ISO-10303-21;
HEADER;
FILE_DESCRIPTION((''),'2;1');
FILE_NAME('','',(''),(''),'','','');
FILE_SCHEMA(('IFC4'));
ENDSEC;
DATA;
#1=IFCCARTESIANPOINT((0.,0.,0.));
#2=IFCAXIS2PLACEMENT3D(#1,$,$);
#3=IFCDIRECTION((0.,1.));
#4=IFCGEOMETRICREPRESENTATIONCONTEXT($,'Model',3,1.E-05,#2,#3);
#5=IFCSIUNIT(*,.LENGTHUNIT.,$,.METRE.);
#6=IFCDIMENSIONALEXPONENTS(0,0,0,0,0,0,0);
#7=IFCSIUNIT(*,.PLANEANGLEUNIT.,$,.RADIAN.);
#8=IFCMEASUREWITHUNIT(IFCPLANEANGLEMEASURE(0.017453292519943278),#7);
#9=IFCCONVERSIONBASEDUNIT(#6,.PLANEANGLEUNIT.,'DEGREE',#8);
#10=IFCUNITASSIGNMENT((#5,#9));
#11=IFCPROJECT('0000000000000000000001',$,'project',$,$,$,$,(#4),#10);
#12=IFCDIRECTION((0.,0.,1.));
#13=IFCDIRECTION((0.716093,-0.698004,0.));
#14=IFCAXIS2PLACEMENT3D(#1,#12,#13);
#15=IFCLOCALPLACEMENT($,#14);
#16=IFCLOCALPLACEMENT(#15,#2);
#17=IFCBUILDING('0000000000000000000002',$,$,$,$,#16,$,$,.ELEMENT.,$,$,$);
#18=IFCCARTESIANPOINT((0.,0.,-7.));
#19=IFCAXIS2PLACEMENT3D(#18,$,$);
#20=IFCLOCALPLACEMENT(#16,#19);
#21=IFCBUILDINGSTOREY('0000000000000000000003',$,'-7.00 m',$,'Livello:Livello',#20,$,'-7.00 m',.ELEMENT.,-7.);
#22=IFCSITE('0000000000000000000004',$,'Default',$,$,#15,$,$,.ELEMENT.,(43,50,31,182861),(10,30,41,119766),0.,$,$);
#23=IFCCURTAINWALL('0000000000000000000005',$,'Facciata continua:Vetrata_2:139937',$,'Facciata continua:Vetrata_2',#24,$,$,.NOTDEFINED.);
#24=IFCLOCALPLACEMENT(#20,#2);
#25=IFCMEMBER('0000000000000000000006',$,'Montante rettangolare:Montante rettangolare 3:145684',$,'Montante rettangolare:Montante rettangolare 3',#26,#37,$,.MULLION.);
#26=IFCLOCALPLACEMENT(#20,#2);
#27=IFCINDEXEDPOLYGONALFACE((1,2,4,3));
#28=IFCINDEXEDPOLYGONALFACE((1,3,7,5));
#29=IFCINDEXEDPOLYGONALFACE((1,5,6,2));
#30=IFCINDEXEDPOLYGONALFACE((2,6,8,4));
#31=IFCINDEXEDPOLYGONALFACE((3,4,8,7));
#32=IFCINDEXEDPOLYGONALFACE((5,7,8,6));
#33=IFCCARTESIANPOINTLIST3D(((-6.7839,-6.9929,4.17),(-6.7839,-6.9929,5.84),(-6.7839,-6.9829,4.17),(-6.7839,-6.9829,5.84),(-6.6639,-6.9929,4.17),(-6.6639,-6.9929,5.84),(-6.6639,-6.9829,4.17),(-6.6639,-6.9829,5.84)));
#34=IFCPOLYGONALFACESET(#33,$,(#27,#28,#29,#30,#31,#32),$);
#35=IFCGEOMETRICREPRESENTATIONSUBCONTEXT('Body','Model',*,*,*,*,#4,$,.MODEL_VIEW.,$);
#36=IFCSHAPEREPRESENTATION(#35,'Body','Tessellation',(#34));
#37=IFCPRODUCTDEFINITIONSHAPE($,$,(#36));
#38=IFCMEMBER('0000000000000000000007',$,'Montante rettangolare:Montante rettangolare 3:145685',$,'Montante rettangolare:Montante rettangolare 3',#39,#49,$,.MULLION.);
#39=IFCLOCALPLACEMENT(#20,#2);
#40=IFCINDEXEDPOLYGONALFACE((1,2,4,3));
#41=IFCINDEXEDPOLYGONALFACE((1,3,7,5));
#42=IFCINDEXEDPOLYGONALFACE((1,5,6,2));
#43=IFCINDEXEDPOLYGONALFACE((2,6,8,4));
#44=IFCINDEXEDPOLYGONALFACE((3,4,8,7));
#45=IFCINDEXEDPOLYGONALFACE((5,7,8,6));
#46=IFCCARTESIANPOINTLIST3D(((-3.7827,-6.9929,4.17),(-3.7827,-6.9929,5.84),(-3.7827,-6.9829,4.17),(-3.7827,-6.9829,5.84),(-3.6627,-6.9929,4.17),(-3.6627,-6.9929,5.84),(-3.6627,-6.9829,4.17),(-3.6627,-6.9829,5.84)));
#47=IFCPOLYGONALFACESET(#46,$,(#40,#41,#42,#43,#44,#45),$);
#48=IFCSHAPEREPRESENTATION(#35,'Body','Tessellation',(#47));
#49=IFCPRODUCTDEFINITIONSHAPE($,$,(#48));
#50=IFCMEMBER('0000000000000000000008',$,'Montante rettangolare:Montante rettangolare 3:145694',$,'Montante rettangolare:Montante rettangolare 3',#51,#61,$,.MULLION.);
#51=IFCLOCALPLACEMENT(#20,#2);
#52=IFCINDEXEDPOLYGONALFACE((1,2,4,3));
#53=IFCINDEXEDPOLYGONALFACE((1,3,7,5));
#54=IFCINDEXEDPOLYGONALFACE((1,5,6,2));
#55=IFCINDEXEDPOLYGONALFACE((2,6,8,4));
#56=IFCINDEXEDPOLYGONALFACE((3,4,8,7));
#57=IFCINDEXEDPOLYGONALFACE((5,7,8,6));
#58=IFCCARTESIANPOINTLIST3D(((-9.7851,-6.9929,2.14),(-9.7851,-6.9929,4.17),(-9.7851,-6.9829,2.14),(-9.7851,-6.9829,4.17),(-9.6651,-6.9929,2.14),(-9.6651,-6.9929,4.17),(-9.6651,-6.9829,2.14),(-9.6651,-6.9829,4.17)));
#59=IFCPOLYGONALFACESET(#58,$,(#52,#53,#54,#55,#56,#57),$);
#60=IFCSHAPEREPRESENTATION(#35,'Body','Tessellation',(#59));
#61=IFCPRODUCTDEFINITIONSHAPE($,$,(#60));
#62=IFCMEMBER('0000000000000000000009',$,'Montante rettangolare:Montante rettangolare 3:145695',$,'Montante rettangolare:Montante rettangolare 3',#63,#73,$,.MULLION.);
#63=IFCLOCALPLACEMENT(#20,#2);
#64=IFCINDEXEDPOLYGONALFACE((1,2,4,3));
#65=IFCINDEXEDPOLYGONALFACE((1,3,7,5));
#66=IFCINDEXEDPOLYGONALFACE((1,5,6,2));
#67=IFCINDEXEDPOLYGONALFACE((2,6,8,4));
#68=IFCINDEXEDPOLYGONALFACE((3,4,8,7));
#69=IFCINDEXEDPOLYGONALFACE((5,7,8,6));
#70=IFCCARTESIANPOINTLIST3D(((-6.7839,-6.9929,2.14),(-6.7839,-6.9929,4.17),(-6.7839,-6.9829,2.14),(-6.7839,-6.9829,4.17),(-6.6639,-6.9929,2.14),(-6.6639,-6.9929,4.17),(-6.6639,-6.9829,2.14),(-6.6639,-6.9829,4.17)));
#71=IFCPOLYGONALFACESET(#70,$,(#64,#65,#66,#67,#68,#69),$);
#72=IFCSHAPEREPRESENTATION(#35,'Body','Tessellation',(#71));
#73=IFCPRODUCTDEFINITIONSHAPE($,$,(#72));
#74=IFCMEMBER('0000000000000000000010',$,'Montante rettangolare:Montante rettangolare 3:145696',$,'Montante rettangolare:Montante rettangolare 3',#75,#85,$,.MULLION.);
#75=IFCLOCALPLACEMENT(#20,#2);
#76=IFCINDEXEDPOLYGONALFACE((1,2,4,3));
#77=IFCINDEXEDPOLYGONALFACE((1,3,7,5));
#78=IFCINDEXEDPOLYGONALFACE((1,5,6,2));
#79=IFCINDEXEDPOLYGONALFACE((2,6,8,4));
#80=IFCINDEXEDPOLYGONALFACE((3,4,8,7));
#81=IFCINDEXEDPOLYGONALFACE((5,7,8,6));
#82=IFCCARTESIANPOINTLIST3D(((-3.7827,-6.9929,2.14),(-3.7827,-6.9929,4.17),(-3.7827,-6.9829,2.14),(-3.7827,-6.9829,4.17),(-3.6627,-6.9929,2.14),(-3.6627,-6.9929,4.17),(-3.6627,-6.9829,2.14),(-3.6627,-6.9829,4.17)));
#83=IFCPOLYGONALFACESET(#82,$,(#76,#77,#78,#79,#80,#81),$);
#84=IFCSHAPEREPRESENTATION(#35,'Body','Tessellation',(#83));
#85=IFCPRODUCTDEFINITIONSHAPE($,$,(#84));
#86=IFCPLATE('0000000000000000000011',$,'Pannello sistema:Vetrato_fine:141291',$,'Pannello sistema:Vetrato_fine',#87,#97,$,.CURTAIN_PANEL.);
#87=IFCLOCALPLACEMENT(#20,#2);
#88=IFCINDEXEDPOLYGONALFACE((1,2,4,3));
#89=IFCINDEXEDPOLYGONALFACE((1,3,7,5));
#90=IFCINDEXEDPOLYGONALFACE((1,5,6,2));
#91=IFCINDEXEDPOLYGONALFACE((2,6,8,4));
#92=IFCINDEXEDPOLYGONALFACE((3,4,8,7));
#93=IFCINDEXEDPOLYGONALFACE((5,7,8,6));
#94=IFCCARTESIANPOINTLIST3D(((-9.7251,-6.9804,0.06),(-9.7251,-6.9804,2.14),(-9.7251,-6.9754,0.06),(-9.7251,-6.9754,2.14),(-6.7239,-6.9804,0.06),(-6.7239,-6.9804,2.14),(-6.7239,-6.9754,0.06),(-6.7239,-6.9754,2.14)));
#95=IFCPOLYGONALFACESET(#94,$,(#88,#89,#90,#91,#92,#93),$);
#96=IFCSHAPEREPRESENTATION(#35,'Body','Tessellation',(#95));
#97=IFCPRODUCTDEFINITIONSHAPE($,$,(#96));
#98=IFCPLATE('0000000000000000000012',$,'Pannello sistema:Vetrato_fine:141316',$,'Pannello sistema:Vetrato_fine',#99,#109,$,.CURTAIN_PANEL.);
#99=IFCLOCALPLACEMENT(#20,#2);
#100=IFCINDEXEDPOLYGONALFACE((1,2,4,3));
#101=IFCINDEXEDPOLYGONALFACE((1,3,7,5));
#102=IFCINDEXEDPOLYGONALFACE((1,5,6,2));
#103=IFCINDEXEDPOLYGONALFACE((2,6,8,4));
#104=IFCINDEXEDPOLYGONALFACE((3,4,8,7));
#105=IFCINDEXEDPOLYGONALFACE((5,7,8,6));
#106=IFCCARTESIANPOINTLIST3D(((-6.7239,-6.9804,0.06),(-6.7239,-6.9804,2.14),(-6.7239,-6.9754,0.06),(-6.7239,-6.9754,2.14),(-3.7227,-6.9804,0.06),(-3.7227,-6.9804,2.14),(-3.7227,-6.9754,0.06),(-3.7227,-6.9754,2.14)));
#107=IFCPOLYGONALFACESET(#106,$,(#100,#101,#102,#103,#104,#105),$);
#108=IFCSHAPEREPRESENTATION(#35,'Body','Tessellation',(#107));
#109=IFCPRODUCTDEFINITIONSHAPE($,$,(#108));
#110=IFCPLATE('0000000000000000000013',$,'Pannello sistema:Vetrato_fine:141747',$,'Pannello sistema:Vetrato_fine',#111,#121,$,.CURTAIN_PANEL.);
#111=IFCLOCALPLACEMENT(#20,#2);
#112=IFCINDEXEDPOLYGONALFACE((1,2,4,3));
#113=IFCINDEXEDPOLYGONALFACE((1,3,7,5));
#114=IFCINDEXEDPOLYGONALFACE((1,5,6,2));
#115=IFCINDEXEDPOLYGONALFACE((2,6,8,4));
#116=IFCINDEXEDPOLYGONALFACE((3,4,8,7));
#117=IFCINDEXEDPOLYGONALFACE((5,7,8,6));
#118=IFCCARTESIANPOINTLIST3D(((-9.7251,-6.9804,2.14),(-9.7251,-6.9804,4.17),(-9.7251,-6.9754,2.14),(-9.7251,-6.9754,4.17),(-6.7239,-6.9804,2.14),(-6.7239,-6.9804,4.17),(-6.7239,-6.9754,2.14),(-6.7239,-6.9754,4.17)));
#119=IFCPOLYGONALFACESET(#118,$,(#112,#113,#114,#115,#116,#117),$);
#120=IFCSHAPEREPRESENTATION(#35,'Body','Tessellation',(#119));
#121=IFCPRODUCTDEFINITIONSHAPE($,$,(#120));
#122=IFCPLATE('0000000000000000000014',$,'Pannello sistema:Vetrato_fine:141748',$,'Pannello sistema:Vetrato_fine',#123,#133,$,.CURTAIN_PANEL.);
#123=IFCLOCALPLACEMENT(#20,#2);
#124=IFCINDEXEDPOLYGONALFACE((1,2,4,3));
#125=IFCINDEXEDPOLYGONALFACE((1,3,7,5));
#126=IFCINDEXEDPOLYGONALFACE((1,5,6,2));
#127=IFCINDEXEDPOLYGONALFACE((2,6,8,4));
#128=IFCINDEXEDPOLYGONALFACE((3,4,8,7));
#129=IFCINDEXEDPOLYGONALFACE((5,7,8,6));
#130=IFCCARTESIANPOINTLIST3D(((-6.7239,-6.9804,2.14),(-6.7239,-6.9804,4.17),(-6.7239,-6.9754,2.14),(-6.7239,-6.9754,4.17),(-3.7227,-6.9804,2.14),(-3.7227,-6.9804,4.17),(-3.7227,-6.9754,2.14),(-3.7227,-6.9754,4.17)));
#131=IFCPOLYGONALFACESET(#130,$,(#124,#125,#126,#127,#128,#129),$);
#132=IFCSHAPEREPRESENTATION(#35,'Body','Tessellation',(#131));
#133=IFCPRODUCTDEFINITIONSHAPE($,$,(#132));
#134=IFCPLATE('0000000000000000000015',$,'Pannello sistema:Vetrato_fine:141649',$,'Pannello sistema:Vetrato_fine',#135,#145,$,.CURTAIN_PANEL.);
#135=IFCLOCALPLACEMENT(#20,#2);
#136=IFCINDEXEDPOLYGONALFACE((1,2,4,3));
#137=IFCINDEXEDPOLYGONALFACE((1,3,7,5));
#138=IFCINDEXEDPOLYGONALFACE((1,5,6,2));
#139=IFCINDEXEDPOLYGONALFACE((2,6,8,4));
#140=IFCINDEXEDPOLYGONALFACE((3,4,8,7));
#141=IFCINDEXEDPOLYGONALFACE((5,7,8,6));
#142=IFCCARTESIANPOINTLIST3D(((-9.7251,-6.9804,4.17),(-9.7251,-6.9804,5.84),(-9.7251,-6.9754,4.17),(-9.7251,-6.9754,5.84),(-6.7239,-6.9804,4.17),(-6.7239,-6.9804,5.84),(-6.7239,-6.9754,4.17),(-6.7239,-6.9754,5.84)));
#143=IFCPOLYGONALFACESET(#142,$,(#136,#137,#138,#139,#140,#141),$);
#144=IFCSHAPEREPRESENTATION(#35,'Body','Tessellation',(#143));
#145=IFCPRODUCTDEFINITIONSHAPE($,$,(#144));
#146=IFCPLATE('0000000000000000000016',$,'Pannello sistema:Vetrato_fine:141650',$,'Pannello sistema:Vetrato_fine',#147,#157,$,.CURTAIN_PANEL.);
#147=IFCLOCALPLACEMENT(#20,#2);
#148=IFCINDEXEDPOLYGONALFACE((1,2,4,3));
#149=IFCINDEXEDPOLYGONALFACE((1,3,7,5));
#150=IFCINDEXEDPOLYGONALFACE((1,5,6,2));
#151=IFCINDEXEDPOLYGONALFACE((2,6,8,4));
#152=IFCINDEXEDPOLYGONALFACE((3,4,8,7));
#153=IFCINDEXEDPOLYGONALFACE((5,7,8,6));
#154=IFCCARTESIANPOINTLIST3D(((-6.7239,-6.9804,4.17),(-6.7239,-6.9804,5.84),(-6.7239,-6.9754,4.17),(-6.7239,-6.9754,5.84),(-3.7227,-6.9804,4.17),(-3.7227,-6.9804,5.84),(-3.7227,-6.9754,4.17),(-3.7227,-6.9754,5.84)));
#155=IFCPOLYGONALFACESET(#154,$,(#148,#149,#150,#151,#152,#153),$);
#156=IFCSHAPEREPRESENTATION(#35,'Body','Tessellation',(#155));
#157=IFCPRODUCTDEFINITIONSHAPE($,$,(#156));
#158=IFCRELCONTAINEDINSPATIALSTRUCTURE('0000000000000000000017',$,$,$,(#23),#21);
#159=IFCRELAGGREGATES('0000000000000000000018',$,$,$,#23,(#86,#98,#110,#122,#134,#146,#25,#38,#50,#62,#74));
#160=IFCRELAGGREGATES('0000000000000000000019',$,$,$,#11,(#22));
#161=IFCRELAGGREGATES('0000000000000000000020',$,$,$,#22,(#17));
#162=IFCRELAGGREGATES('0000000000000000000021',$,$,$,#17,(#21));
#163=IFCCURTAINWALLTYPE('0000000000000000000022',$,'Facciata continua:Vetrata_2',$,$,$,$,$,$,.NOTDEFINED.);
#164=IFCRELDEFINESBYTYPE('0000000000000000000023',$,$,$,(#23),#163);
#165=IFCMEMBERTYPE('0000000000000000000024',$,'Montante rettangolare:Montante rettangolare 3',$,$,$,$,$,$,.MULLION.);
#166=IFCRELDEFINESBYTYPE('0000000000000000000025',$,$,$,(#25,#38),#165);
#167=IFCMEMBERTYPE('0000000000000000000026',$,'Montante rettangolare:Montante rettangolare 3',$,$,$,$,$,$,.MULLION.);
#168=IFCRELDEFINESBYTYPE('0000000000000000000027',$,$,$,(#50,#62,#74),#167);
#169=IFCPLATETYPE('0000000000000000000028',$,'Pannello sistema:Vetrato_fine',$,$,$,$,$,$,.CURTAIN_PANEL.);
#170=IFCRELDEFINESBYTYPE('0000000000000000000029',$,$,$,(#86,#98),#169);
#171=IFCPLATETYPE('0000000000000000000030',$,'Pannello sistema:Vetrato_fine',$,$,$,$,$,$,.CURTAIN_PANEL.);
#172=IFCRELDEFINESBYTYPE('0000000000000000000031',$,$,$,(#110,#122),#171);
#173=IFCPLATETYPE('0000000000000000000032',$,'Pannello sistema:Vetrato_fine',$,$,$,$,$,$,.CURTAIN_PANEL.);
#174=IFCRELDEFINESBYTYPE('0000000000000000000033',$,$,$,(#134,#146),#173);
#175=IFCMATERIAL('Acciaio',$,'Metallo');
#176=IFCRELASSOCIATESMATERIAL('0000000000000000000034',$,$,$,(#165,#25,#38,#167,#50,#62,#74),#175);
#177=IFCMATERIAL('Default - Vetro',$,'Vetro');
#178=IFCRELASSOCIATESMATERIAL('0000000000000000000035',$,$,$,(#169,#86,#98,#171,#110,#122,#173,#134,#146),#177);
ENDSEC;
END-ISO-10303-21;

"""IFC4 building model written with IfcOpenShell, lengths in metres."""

from ifc_helpers import new_model, entity, si_unit, converted_unit, direction, frame, origin, place, context, subcontext, project, spatial, indexed_curve, outline, extrude, source, transform, mapped, material, type_object, type_shapes, element, aggregate, save


model = new_model("IFC4")

# Units and contexts
model_context = context("Model", 3, precision=1e-05, world=origin(), true_north=direction((0.0, 1.0)))
body_context = subcontext(model_context, "Body", "Model", "MODEL_VIEW")
ifc_project = project(units=[si_unit("LENGTHUNIT", "METRE"), converted_unit("PLANEANGLEUNIT", "DEGREE", entity("IfcPlaneAngleMeasure", 0.017453292519943278), si_unit("PLANEANGLEUNIT", "RADIAN"), dimensions=[0, 0, 0, 0, 0, 0, 0])], contexts=[model_context])

# Site, building, storey
site_placement = place(None, frame((0.0, 0.0, 0.0), z_axis=(0.0, 0.0, 1.0), x_axis=(0.716093, -0.698004, 0.0)))
site = spatial("IfcSite", under=ifc_project, at=site_placement, Name="Default", CompositionType="ELEMENT", RefLatitude=(43, 50, 31, 182861), RefLongitude=(10, 30, 41, 119766), RefElevation=0.0)
building_placement = place(site_placement, origin())
building = spatial("IfcBuilding", under=site, at=building_placement, CompositionType="ELEMENT")
storey_placement = place(building_placement, frame((0.0, 0.0, -7.0)))
storey = spatial("IfcBuildingStorey", under=building, at=storey_placement, Name="-7.00 m", ObjectType="Livello:Livello", LongName="-7.00 m", CompositionType="ELEMENT", Elevation=-7.0)

# Curtain wall, members, plates
curtain_wall_type = type_object("IfcCurtainWallType", Name="Facciata continua:Vetrata_2", PredefinedType="NOTDEFINED")
curtain_wall_placement = place(storey_placement, frame((0.0, 0.0, 7.0)))
curtain_wall = element("IfcCurtainWall", 1, at=curtain_wall_placement, inside=storey, type_object=curtain_wall_type, Name="Facciata continua:Vetrata_2:139937", ObjectType="Facciata continua:Vetrata_2", PredefinedType="NOTDEFINED")
ifc_material_1 = material(Name="Acciaio", Category="Metallo")
member_type_1 = type_object("IfcMemberType", Name="Montante rettangolare:Montante rettangolare 3", PredefinedType="MULLION", material=ifc_material_1)
shared_shape_1 = source(origin(), body_context, "Body", "SweptSolid", [
    extrude(outline(indexed_curve([(-0.06, -0.005), (0.06, -0.005), (0.06, 0.005), (-0.06, 0.005), (-0.06, -0.005)], self_intersect=False)), frame((0.0, 0.01, -1.67), z_axis=(0.0, 0.0, 1.0), x_axis=(-1.0, 0.0, 0.0)), (0.0, 0.0, 1.0), 1.67),
])
type_shapes(member_type_1, [shared_shape_1])
member_1_placement = place(curtain_wall_placement, frame((-6.7239, -6.9779, -2.83), z_axis=(0.0, 0.0, -1.0), x_axis=(1.0, 0.0, 0.0)))
member_1 = element("IfcMember", 2, at=member_1_placement, type_object=member_type_1, material=ifc_material_1, Name="Montante rettangolare:Montante rettangolare 3:145684", ObjectType="Montante rettangolare:Montante rettangolare 3", PredefinedType="MULLION", context=body_context, shape_type="MappedRepresentation", body=[
    mapped(shared_shape_1, transform((0.0, 0.0, 0.0), scale=1.0)),
])
member_2_placement = place(curtain_wall_placement, frame((-3.7227, -6.9779, -2.83), z_axis=(0.0, 0.0, -1.0), x_axis=(1.0, 0.0, 0.0)))
member_2 = element("IfcMember", 3, at=member_2_placement, type_object=member_type_1, material=ifc_material_1, Name="Montante rettangolare:Montante rettangolare 3:145685", ObjectType="Montante rettangolare:Montante rettangolare 3", PredefinedType="MULLION", context=body_context, shape_type="MappedRepresentation", body=[
    mapped(shared_shape_1, transform((0.0, 0.0, 0.0), scale=1.0)),
])
member_type_2 = type_object("IfcMemberType", Name="Montante rettangolare:Montante rettangolare 3", PredefinedType="MULLION", material=ifc_material_1)
shared_shape_2 = source(origin(), body_context, "Body", "SweptSolid", [
    extrude(outline(indexed_curve([(-0.06, -0.005), (0.06, -0.005), (0.06, 0.005), (-0.06, 0.005), (-0.06, -0.005)], self_intersect=False)), frame((0.0, 0.01, -2.03), z_axis=(0.0, 0.0, 1.0), x_axis=(-1.0, 0.0, 0.0)), (0.0, 0.0, 1.0), 2.03),
])
type_shapes(member_type_2, [shared_shape_2])
member_3_placement = place(curtain_wall_placement, frame((-9.7251, -6.9779, -4.86), z_axis=(0.0, 0.0, -1.0), x_axis=(1.0, 0.0, 0.0)))
member_3 = element("IfcMember", 4, at=member_3_placement, type_object=member_type_2, material=ifc_material_1, Name="Montante rettangolare:Montante rettangolare 3:145694", ObjectType="Montante rettangolare:Montante rettangolare 3", PredefinedType="MULLION", context=body_context, shape_type="MappedRepresentation", body=[
    mapped(shared_shape_2, transform((0.0, 0.0, 0.0), scale=1.0)),
])
member_4_placement = place(curtain_wall_placement, frame((-6.7239, -6.9779, -4.86), z_axis=(0.0, 0.0, -1.0), x_axis=(1.0, 0.0, 0.0)))
member_4 = element("IfcMember", 5, at=member_4_placement, type_object=member_type_2, material=ifc_material_1, Name="Montante rettangolare:Montante rettangolare 3:145695", ObjectType="Montante rettangolare:Montante rettangolare 3", PredefinedType="MULLION", context=body_context, shape_type="MappedRepresentation", body=[
    mapped(shared_shape_2, transform((0.0, 0.0, 0.0), scale=1.0)),
])
member_5_placement = place(curtain_wall_placement, frame((-3.7227, -6.9779, -4.86), z_axis=(0.0, 0.0, -1.0), x_axis=(1.0, 0.0, 0.0)))
member_5 = element("IfcMember", 6, at=member_5_placement, type_object=member_type_2, material=ifc_material_1, Name="Montante rettangolare:Montante rettangolare 3:145696", ObjectType="Montante rettangolare:Montante rettangolare 3", PredefinedType="MULLION", context=body_context, shape_type="MappedRepresentation", body=[
    mapped(shared_shape_2, transform((0.0, 0.0, 0.0), scale=1.0)),
])
ifc_material_2 = material(Name="Default - Vetro", Category="Vetro")
plate_type_1 = type_object("IfcPlateType", Name="Pannello sistema:Vetrato_fine", PredefinedType="CURTAIN_PANEL", material=ifc_material_2)
shared_shape_3 = source(origin(), body_context, "Body", "SweptSolid", [
    extrude(outline(indexed_curve([(-0.0025, -1.5006), (0.0025, -1.5006), (0.0025, 1.5006), (-0.0025, 1.5006), (-0.0025, -1.5006)], self_intersect=False)), frame((0.0, 0.0, 0.0), z_axis=(0.0, 0.0, 1.0), x_axis=(0.0, 1.0, 0.0)), (0.0, 0.0, 1.0), 2.08),
])
type_shapes(plate_type_1, [shared_shape_3])
plate_1_placement = place(curtain_wall_placement, frame((-8.2245, -6.9779, -6.94)))
plate_1 = element("IfcPlate", 7, at=plate_1_placement, type_object=plate_type_1, material=ifc_material_2, Name="Pannello sistema:Vetrato_fine:141291", ObjectType="Pannello sistema:Vetrato_fine", PredefinedType="CURTAIN_PANEL", context=body_context, shape_type="MappedRepresentation", body=[
    mapped(shared_shape_3, transform((0.0, 0.0, 0.0), scale=1.0)),
])
plate_2_placement = place(curtain_wall_placement, frame((-5.2233, -6.9779, -6.94)))
plate_2 = element("IfcPlate", 8, at=plate_2_placement, type_object=plate_type_1, material=ifc_material_2, Name="Pannello sistema:Vetrato_fine:141316", ObjectType="Pannello sistema:Vetrato_fine", PredefinedType="CURTAIN_PANEL", context=body_context, shape_type="MappedRepresentation", body=[
    mapped(shared_shape_3, transform((0.0, 0.0, 0.0), scale=1.0)),
])
plate_type_2 = type_object("IfcPlateType", Name="Pannello sistema:Vetrato_fine", PredefinedType="CURTAIN_PANEL", material=ifc_material_2)
shared_shape_4 = source(origin(), body_context, "Body", "SweptSolid", [
    extrude(outline(indexed_curve([(-0.0025, -1.5006), (0.0025, -1.5006), (0.0025, 1.5006), (-0.0025, 1.5006), (-0.0025, -1.5006)], self_intersect=False)), frame((0.0, 0.0, 0.0), z_axis=(0.0, 0.0, 1.0), x_axis=(0.0, 1.0, 0.0)), (0.0, 0.0, 1.0), 2.03),
])
type_shapes(plate_type_2, [shared_shape_4])
plate_3_placement = place(curtain_wall_placement, frame((-8.2245, -6.9779, -4.86)))
plate_3 = element("IfcPlate", 9, at=plate_3_placement, type_object=plate_type_2, material=ifc_material_2, Name="Pannello sistema:Vetrato_fine:141747", ObjectType="Pannello sistema:Vetrato_fine", PredefinedType="CURTAIN_PANEL", context=body_context, shape_type="MappedRepresentation", body=[
    mapped(shared_shape_4, transform((0.0, 0.0, 0.0), scale=1.0)),
])
plate_4_placement = place(curtain_wall_placement, frame((-5.2233, -6.9779, -4.86)))
plate_4 = element("IfcPlate", 10, at=plate_4_placement, type_object=plate_type_2, material=ifc_material_2, Name="Pannello sistema:Vetrato_fine:141748", ObjectType="Pannello sistema:Vetrato_fine", PredefinedType="CURTAIN_PANEL", context=body_context, shape_type="MappedRepresentation", body=[
    mapped(shared_shape_4, transform((0.0, 0.0, 0.0), scale=1.0)),
])
plate_type_3 = type_object("IfcPlateType", Name="Pannello sistema:Vetrato_fine", PredefinedType="CURTAIN_PANEL", material=ifc_material_2)
shared_shape_5 = source(origin(), body_context, "Body", "SweptSolid", [
    extrude(outline(indexed_curve([(-0.0025, -1.5006), (0.0025, -1.5006), (0.0025, 1.5006), (-0.0025, 1.5006), (-0.0025, -1.5006)], self_intersect=False)), frame((0.0, 0.0, 0.0), z_axis=(0.0, 0.0, 1.0), x_axis=(0.0, 1.0, 0.0)), (0.0, 0.0, 1.0), 1.67),
])
type_shapes(plate_type_3, [shared_shape_5])
plate_5_placement = place(curtain_wall_placement, frame((-8.2245, -6.9779, -2.83)))
plate_5 = element("IfcPlate", 11, at=plate_5_placement, type_object=plate_type_3, material=ifc_material_2, Name="Pannello sistema:Vetrato_fine:141649", ObjectType="Pannello sistema:Vetrato_fine", PredefinedType="CURTAIN_PANEL", context=body_context, shape_type="MappedRepresentation", body=[
    mapped(shared_shape_5, transform((0.0, 0.0, 0.0), scale=1.0)),
])
plate_6_placement = place(curtain_wall_placement, frame((-5.2233, -6.9779, -2.83)))
plate_6 = element("IfcPlate", 12, at=plate_6_placement, type_object=plate_type_3, material=ifc_material_2, Name="Pannello sistema:Vetrato_fine:141650", ObjectType="Pannello sistema:Vetrato_fine", PredefinedType="CURTAIN_PANEL", context=body_context, shape_type="MappedRepresentation", body=[
    mapped(shared_shape_5, transform((0.0, 0.0, 0.0), scale=1.0)),
])
aggregate(curtain_wall, [plate_1, plate_2, plate_3, plate_4, plate_5, plate_6, member_1, member_2, member_3, member_4, member_5])

save(model, "model.ifc")
